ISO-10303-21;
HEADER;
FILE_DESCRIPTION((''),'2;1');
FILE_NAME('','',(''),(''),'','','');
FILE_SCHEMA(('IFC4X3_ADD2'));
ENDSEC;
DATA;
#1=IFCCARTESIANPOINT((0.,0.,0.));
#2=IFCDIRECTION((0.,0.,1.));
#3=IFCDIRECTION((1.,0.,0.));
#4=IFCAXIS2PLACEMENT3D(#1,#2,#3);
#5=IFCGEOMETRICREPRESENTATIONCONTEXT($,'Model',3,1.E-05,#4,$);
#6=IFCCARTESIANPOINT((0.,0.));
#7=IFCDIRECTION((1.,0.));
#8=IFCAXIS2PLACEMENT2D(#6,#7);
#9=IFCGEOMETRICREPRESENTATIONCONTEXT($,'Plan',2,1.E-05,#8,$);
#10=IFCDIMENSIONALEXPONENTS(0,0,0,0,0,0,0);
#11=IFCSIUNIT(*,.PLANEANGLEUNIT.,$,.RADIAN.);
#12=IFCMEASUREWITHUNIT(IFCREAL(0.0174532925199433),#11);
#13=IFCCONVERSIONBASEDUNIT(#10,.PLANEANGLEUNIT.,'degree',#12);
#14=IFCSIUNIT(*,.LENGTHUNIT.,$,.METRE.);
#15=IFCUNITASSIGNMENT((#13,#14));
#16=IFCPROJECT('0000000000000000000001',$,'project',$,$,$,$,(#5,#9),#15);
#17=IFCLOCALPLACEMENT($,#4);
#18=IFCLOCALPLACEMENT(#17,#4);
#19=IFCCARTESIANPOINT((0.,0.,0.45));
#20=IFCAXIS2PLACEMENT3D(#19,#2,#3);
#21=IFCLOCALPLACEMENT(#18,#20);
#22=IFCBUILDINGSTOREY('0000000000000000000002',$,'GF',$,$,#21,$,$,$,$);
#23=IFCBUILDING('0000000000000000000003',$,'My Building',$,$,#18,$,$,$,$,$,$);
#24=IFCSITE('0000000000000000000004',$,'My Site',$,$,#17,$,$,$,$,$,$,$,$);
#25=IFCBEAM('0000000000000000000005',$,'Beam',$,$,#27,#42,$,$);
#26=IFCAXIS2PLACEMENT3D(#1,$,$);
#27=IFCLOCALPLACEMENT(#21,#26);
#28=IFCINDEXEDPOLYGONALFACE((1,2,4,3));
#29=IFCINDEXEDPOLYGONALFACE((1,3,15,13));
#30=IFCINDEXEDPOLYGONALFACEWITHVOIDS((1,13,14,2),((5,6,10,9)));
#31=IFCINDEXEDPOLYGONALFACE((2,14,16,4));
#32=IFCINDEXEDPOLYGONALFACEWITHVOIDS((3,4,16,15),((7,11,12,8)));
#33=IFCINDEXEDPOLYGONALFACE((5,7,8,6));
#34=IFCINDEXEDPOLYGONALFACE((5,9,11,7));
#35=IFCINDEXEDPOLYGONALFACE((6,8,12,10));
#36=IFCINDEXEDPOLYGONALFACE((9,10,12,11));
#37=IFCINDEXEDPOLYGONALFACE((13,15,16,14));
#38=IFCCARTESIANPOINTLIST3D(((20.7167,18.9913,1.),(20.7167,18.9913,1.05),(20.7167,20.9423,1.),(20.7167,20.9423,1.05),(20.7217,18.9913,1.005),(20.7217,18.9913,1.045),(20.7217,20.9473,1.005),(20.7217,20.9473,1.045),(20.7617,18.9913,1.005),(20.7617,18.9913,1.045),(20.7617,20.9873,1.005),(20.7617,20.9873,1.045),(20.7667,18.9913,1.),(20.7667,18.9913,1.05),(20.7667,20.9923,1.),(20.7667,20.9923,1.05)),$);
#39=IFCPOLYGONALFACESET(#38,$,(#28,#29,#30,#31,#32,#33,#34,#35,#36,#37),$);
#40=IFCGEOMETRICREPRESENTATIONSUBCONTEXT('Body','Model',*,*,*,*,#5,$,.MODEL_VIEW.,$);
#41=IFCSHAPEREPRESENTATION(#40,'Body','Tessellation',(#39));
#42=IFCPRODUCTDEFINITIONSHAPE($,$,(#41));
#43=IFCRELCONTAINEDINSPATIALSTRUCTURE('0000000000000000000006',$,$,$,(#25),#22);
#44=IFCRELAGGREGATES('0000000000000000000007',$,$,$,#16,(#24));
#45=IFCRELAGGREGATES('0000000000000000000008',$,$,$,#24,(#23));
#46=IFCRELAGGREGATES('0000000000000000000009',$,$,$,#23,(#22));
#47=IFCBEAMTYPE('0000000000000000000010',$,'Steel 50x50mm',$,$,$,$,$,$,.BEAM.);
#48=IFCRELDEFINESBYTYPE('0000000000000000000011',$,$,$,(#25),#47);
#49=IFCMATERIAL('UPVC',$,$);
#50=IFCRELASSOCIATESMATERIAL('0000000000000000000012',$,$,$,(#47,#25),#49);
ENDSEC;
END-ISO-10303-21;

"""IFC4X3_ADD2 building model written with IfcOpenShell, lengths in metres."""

from ifc_helpers import new_model, entity, si_unit, converted_unit, frame, origin_with_axes, origin_2d_with_axis, place, context, subcontext, project, spatial, hollow_rectangle, extrude, clip, halfspace, material, material_profile, profile_set, profile_usage, type_object, element, save


model = new_model("IFC4X3_ADD2")

# Units and contexts
model_context = context("Model", 3, precision=1e-05, world=origin_with_axes())
plan_context = context("Plan", 2, precision=1e-05, world=origin_2d_with_axis())
body_context_1 = subcontext(model_context, "Body", "Model", "MODEL_VIEW")
ifc_project = project(units=[converted_unit("PLANEANGLEUNIT", "degree", entity("IfcReal", 0.0174532925199433), si_unit("PLANEANGLEUNIT", "RADIAN"), dimensions=[0, 0, 0, 0, 0, 0, 0]), si_unit("LENGTHUNIT", "METRE")], contexts=[model_context, plan_context])

# Site, building, storey
site_placement = place(None, origin_with_axes())
site = spatial("IfcSite", under=ifc_project, at=site_placement, Name="My Site")
building_placement = place(site_placement, origin_with_axes())
building = spatial("IfcBuilding", under=site, at=building_placement, Name="My Building")
storey_placement = place(building_placement, frame((0.0, 0.0, 0.45), z_axis=(0.0, 0.0, 1.0), x_axis=(1.0, 0.0, 0.0)))
storey = spatial("IfcBuildingStorey", under=building, at=storey_placement, Name="GF")

# Beam
ifc_material_1 = material(Name="UPVC")
ifc_material_profile_1 = material_profile(ifc_material_1, hollow_rectangle(XDim=0.05, YDim=0.05, WallThickness=0.005))
ifc_material_profile_2 = material_profile(ifc_material_1, hollow_rectangle(XDim=0.05, YDim=0.05, WallThickness=0.005))
ifc_profile_set = profile_set([ifc_material_profile_1, ifc_material_profile_2])
ifc_profile_usage = profile_usage(ifc_profile_set, cardinal=5)
beam_type = type_object("IfcBeamType", Name="Steel 50x50mm", PredefinedType="BEAM", material=ifc_profile_set)
beam_placement = place(storey_placement, frame((20.7417, 18.9913, 1.025), z_axis=(0.0, 1.0, 0.0), x_axis=(-1.0, 0.0, 0.0)))
element("IfcBeam", 1, at=beam_placement, inside=storey, type_object=beam_type, material=ifc_profile_usage, Name="Beam", context=body_context_1, shape_type="Clipping", body=[
    clip(extrude(hollow_rectangle(XDim=0.05, YDim=0.05, WallThickness=0.005), origin_with_axes(), (0.0, 0.0, 1.0), 2.0009), halfspace(frame((-0.025, -1.475, 2.0009), z_axis=(0.707107, 0.0, 0.707107), x_axis=(0.0, -1.0, 0.0)), False)),
])

save(model, "model.ifc")
